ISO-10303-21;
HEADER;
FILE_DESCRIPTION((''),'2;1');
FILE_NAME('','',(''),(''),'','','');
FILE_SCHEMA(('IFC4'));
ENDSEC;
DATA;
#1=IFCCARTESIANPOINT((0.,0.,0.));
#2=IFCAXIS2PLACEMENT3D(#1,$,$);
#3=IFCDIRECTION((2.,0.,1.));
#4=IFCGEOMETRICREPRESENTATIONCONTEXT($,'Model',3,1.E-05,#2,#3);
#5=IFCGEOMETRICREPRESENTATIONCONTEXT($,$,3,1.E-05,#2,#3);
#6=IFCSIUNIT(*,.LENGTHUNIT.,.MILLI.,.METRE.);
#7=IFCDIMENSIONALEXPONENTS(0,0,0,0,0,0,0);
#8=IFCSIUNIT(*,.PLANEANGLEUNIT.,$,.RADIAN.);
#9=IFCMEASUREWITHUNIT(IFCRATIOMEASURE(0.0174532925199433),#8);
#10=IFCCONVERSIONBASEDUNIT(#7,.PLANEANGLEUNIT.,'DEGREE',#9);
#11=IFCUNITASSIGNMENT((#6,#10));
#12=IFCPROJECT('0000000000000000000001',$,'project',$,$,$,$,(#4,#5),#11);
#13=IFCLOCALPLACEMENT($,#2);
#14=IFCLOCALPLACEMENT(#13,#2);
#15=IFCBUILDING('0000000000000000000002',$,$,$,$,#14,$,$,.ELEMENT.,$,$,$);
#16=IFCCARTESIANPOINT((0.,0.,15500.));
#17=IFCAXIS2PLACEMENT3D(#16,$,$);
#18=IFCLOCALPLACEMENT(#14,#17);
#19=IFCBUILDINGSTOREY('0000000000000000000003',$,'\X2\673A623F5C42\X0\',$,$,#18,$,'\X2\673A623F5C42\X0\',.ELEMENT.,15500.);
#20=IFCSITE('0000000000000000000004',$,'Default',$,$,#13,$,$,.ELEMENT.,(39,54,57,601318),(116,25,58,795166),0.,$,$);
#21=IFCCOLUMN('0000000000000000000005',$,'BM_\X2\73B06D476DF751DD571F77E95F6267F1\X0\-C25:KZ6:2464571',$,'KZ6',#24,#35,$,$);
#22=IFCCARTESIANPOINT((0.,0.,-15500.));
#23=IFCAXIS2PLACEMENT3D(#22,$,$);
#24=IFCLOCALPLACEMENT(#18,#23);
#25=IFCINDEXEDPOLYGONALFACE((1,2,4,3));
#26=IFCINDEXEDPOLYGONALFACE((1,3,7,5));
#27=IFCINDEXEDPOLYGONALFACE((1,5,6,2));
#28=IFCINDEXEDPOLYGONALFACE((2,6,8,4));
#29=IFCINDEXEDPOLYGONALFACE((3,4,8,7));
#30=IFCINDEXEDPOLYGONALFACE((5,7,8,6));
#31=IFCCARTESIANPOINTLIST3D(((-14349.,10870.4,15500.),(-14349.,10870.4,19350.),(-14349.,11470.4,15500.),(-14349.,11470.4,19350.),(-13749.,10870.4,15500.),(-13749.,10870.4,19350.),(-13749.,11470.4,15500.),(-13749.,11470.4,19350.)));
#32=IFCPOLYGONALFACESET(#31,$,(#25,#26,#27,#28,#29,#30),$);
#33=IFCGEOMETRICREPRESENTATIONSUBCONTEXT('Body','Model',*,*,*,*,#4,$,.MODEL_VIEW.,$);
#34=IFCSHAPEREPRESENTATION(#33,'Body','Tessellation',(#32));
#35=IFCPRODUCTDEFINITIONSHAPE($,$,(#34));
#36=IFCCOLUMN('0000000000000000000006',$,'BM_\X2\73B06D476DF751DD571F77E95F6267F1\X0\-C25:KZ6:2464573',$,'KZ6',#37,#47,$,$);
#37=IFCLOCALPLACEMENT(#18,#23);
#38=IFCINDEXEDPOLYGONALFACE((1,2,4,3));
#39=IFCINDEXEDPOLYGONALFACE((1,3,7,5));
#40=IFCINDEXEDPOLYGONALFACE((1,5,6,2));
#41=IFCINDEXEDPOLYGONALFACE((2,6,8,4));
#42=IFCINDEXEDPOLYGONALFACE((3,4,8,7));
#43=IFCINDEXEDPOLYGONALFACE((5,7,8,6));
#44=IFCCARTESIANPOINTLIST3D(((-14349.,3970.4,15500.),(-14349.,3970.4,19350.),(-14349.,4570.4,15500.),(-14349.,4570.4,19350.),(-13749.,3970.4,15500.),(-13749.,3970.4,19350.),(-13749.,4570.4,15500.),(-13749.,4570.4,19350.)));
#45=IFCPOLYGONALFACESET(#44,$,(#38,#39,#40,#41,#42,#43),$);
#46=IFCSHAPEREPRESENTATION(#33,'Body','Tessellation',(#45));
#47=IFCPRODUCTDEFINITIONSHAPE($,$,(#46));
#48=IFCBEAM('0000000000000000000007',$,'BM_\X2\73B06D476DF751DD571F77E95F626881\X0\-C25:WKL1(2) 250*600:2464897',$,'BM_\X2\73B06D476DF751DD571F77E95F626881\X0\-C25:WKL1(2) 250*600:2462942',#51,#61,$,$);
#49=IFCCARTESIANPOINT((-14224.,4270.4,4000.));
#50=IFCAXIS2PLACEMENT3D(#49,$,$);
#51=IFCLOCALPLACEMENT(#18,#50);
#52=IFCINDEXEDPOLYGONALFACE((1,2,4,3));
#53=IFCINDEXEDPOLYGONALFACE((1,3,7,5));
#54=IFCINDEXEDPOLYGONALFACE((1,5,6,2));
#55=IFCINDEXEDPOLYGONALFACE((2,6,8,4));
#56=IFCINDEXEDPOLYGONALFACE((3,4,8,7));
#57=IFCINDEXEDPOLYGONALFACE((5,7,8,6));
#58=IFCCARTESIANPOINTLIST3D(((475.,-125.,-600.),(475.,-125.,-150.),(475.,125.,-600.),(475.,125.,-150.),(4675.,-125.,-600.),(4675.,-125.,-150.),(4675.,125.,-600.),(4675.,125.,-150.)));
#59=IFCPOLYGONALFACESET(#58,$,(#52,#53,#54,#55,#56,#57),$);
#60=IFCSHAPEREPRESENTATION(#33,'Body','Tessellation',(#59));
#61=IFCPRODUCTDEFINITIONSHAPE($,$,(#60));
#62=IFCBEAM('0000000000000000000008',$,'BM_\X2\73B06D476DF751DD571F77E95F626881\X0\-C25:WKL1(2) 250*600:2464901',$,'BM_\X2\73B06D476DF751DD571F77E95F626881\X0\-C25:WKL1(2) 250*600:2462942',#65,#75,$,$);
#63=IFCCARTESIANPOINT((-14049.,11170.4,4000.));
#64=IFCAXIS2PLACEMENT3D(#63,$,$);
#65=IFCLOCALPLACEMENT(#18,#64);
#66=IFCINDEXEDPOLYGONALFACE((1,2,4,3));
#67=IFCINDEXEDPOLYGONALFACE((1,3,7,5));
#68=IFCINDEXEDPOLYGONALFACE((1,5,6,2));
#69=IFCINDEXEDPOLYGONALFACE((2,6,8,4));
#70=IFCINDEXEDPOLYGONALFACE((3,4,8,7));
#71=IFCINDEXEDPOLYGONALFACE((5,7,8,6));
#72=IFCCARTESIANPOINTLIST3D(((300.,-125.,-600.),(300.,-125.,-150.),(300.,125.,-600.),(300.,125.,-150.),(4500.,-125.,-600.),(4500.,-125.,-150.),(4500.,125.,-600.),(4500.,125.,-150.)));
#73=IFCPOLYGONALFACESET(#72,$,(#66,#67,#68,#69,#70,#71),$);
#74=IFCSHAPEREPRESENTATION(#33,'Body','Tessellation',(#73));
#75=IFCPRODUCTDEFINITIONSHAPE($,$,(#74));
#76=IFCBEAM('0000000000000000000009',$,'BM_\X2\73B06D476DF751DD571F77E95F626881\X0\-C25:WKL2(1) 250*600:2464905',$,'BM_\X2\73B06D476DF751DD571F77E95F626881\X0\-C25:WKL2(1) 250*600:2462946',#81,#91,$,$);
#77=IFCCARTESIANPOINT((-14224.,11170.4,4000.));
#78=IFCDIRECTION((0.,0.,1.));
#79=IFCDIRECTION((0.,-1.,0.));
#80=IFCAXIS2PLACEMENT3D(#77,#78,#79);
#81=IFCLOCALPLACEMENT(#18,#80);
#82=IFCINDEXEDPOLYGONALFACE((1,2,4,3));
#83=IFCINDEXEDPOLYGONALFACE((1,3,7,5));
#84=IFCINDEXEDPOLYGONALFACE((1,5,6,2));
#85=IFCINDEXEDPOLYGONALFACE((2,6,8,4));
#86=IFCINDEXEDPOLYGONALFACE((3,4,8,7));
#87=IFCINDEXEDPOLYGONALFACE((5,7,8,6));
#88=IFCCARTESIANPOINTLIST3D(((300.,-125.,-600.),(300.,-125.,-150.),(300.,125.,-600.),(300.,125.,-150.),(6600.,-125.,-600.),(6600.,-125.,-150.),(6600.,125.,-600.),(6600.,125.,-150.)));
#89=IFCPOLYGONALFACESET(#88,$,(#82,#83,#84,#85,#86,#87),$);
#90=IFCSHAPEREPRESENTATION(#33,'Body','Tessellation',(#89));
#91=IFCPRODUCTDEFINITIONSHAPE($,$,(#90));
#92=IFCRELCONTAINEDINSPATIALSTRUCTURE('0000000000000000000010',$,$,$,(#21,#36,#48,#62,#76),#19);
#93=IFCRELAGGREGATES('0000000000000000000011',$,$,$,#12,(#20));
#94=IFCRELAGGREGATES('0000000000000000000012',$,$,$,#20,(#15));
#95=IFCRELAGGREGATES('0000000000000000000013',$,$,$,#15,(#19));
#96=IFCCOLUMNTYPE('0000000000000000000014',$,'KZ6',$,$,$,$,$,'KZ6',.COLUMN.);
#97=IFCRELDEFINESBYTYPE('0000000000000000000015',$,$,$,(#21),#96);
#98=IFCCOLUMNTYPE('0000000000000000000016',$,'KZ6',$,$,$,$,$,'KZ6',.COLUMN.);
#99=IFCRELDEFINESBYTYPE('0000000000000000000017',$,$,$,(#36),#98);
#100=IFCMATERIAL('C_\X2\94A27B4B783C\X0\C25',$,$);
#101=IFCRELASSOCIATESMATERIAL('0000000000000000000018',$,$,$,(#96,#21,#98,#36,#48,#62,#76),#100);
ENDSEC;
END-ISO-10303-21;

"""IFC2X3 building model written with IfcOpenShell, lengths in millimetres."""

from ifc_helpers import new_model, entity, si_unit, converted_unit, direction, frame, frame_2d, origin, place, context, subcontext, project, spatial, rectangle, extrude, source, transform, mapped, material, type_object, type_shapes, element, save


model = new_model("IFC2X3")

# Units and contexts
model_context = context("Model", 3, precision=1e-05, world=origin(), true_north=direction((2.0, 0.0, 1.0)))
context_of_model = context(None, 3, precision=1e-05, world=origin(), true_north=direction((2.0, 0.0, 1.0)))
body_context = subcontext(model_context, "Body", "Model", "MODEL_VIEW")
ifc_project = project(units=[si_unit("LENGTHUNIT", "METRE", prefix="MILLI"), converted_unit("PLANEANGLEUNIT", "DEGREE", entity("IfcRatioMeasure", 0.0174532925199433), si_unit("PLANEANGLEUNIT", "RADIAN"), dimensions=[0, 0, 0, 0, 0, 0, 0])], contexts=[model_context, context_of_model])

# Site, building, storey
site_placement = place(None, origin())
site = spatial("IfcSite", under=ifc_project, at=site_placement, Name="Default", CompositionType="ELEMENT", RefLatitude=(39, 54, 57, 601318), RefLongitude=(116, 25, 58, 795166), RefElevation=0.0)
building_placement = place(site_placement, origin())
building = spatial("IfcBuilding", under=site, at=building_placement, CompositionType="ELEMENT")
storey_placement = place(building_placement, frame((0.0, 0.0, 15500.0)))
storey = spatial("IfcBuildingStorey", under=building, at=storey_placement, Name="机房层", LongName="机房层", CompositionType="ELEMENT", Elevation=15500.0)

# Columns
ifc_material = material(Name="C_钢筋砼C25")
column_type_1 = type_object("IfcColumnType", Name="KZ6", ElementType="KZ6", PredefinedType="COLUMN", material=ifc_material)
shared_shape_1 = source(origin(), body_context, "Body", "SweptSolid", [
    extrude(rectangle(XDim=600.0, YDim=600.0, at=frame_2d((0.0, 0.0), x_axis=(1.0, 0.0))), frame((-14049.0, 11170.4, 15500.0), z_axis=(0.0, 0.0, 1.0), x_axis=(-1.0, 0.0, 0.0)), (0.0, 0.0, 1.0), 3850.0),
])
type_shapes(column_type_1, [shared_shape_1])
column_1_placement = place(storey_placement, frame((0.0, 0.0, -15500.0)))
element("IfcColumn", 1, at=column_1_placement, inside=storey, type_object=column_type_1, material=ifc_material, Name="BM_现浇混凝土矩形柱-C25:KZ6:2464571", ObjectType="KZ6", context=body_context, shape_type="MappedRepresentation", body=[
    mapped(shared_shape_1, transform((0.0, 0.0, 0.0), scale=1.0)),
])
column_type_2 = type_object("IfcColumnType", Name="KZ6", ElementType="KZ6", PredefinedType="COLUMN", material=ifc_material)
shared_shape_2 = source(origin(), body_context, "Body", "SweptSolid", [
    extrude(rectangle(XDim=600.0, YDim=600.0, at=frame_2d((0.0, 0.0), x_axis=(1.0, 0.0))), frame((-14049.0, 4270.4, 15500.0), z_axis=(0.0, 0.0, 1.0), x_axis=(-1.0, 0.0, 0.0)), (0.0, 0.0, 1.0), 3850.0),
])
type_shapes(column_type_2, [shared_shape_2])
column_2_placement = place(storey_placement, frame((0.0, 0.0, -15500.0)))
element("IfcColumn", 2, at=column_2_placement, inside=storey, type_object=column_type_2, material=ifc_material, Name="BM_现浇混凝土矩形柱-C25:KZ6:2464573", ObjectType="KZ6", context=body_context, shape_type="MappedRepresentation", body=[
    mapped(shared_shape_2, transform((0.0, 0.0, 0.0), scale=1.0)),
])

# Beams
beam_1_placement = place(storey_placement, frame((-14224.0, 4270.4, 4000.0)))
element("IfcBeam", 3, at=beam_1_placement, inside=storey, material=ifc_material, Name="BM_现浇混凝土矩形梁-C25:WKL1(2) 250*600:2464897", ObjectType="BM_现浇混凝土矩形梁-C25:WKL1(2) 250*600:2462942", context=body_context, shape_type="SweptSolid", body=[
    extrude(rectangle(XDim=450.0, YDim=250.0, at=frame_2d((0.0, 0.0), x_axis=(1.0, 0.0))), frame((475.0, 0.0, -375.0), z_axis=(1.0, 0.0, 0.0), x_axis=(0.0, 0.0, -1.0)), (0.0, 0.0, 1.0), 4200.0),
])
beam_2_placement = place(storey_placement, frame((-14049.0, 11170.4, 4000.0)))
element("IfcBeam", 4, at=beam_2_placement, inside=storey, material=ifc_material, Name="BM_现浇混凝土矩形梁-C25:WKL1(2) 250*600:2464901", ObjectType="BM_现浇混凝土矩形梁-C25:WKL1(2) 250*600:2462942", context=body_context, shape_type="SweptSolid", body=[
    extrude(rectangle(XDim=450.0, YDim=250.0, at=frame_2d((0.0, 0.0), x_axis=(1.0, 0.0))), frame((300.0, 0.0, -375.0), z_axis=(1.0, 0.0, 0.0), x_axis=(0.0, 0.0, -1.0)), (0.0, 0.0, 1.0), 4200.0),
])
beam_3_placement = place(storey_placement, frame((-14224.0, 11170.4, 4000.0), z_axis=(0.0, 0.0, 1.0), x_axis=(0.0, -1.0, 0.0)))
element("IfcBeam", 5, at=beam_3_placement, inside=storey, material=ifc_material, Name="BM_现浇混凝土矩形梁-C25:WKL2(1) 250*600:2464905", ObjectType="BM_现浇混凝土矩形梁-C25:WKL2(1) 250*600:2462946", context=body_context, shape_type="SweptSolid", body=[
    extrude(rectangle(XDim=450.0, YDim=250.0, at=frame_2d((0.0, 0.0), x_axis=(1.0, 0.0))), frame((300.0, 0.0, -375.0), z_axis=(1.0, 0.0, 0.0), x_axis=(0.0, 0.0, -1.0)), (0.0, 0.0, 1.0), 6300.0),
])

save(model, "model.ifc")
